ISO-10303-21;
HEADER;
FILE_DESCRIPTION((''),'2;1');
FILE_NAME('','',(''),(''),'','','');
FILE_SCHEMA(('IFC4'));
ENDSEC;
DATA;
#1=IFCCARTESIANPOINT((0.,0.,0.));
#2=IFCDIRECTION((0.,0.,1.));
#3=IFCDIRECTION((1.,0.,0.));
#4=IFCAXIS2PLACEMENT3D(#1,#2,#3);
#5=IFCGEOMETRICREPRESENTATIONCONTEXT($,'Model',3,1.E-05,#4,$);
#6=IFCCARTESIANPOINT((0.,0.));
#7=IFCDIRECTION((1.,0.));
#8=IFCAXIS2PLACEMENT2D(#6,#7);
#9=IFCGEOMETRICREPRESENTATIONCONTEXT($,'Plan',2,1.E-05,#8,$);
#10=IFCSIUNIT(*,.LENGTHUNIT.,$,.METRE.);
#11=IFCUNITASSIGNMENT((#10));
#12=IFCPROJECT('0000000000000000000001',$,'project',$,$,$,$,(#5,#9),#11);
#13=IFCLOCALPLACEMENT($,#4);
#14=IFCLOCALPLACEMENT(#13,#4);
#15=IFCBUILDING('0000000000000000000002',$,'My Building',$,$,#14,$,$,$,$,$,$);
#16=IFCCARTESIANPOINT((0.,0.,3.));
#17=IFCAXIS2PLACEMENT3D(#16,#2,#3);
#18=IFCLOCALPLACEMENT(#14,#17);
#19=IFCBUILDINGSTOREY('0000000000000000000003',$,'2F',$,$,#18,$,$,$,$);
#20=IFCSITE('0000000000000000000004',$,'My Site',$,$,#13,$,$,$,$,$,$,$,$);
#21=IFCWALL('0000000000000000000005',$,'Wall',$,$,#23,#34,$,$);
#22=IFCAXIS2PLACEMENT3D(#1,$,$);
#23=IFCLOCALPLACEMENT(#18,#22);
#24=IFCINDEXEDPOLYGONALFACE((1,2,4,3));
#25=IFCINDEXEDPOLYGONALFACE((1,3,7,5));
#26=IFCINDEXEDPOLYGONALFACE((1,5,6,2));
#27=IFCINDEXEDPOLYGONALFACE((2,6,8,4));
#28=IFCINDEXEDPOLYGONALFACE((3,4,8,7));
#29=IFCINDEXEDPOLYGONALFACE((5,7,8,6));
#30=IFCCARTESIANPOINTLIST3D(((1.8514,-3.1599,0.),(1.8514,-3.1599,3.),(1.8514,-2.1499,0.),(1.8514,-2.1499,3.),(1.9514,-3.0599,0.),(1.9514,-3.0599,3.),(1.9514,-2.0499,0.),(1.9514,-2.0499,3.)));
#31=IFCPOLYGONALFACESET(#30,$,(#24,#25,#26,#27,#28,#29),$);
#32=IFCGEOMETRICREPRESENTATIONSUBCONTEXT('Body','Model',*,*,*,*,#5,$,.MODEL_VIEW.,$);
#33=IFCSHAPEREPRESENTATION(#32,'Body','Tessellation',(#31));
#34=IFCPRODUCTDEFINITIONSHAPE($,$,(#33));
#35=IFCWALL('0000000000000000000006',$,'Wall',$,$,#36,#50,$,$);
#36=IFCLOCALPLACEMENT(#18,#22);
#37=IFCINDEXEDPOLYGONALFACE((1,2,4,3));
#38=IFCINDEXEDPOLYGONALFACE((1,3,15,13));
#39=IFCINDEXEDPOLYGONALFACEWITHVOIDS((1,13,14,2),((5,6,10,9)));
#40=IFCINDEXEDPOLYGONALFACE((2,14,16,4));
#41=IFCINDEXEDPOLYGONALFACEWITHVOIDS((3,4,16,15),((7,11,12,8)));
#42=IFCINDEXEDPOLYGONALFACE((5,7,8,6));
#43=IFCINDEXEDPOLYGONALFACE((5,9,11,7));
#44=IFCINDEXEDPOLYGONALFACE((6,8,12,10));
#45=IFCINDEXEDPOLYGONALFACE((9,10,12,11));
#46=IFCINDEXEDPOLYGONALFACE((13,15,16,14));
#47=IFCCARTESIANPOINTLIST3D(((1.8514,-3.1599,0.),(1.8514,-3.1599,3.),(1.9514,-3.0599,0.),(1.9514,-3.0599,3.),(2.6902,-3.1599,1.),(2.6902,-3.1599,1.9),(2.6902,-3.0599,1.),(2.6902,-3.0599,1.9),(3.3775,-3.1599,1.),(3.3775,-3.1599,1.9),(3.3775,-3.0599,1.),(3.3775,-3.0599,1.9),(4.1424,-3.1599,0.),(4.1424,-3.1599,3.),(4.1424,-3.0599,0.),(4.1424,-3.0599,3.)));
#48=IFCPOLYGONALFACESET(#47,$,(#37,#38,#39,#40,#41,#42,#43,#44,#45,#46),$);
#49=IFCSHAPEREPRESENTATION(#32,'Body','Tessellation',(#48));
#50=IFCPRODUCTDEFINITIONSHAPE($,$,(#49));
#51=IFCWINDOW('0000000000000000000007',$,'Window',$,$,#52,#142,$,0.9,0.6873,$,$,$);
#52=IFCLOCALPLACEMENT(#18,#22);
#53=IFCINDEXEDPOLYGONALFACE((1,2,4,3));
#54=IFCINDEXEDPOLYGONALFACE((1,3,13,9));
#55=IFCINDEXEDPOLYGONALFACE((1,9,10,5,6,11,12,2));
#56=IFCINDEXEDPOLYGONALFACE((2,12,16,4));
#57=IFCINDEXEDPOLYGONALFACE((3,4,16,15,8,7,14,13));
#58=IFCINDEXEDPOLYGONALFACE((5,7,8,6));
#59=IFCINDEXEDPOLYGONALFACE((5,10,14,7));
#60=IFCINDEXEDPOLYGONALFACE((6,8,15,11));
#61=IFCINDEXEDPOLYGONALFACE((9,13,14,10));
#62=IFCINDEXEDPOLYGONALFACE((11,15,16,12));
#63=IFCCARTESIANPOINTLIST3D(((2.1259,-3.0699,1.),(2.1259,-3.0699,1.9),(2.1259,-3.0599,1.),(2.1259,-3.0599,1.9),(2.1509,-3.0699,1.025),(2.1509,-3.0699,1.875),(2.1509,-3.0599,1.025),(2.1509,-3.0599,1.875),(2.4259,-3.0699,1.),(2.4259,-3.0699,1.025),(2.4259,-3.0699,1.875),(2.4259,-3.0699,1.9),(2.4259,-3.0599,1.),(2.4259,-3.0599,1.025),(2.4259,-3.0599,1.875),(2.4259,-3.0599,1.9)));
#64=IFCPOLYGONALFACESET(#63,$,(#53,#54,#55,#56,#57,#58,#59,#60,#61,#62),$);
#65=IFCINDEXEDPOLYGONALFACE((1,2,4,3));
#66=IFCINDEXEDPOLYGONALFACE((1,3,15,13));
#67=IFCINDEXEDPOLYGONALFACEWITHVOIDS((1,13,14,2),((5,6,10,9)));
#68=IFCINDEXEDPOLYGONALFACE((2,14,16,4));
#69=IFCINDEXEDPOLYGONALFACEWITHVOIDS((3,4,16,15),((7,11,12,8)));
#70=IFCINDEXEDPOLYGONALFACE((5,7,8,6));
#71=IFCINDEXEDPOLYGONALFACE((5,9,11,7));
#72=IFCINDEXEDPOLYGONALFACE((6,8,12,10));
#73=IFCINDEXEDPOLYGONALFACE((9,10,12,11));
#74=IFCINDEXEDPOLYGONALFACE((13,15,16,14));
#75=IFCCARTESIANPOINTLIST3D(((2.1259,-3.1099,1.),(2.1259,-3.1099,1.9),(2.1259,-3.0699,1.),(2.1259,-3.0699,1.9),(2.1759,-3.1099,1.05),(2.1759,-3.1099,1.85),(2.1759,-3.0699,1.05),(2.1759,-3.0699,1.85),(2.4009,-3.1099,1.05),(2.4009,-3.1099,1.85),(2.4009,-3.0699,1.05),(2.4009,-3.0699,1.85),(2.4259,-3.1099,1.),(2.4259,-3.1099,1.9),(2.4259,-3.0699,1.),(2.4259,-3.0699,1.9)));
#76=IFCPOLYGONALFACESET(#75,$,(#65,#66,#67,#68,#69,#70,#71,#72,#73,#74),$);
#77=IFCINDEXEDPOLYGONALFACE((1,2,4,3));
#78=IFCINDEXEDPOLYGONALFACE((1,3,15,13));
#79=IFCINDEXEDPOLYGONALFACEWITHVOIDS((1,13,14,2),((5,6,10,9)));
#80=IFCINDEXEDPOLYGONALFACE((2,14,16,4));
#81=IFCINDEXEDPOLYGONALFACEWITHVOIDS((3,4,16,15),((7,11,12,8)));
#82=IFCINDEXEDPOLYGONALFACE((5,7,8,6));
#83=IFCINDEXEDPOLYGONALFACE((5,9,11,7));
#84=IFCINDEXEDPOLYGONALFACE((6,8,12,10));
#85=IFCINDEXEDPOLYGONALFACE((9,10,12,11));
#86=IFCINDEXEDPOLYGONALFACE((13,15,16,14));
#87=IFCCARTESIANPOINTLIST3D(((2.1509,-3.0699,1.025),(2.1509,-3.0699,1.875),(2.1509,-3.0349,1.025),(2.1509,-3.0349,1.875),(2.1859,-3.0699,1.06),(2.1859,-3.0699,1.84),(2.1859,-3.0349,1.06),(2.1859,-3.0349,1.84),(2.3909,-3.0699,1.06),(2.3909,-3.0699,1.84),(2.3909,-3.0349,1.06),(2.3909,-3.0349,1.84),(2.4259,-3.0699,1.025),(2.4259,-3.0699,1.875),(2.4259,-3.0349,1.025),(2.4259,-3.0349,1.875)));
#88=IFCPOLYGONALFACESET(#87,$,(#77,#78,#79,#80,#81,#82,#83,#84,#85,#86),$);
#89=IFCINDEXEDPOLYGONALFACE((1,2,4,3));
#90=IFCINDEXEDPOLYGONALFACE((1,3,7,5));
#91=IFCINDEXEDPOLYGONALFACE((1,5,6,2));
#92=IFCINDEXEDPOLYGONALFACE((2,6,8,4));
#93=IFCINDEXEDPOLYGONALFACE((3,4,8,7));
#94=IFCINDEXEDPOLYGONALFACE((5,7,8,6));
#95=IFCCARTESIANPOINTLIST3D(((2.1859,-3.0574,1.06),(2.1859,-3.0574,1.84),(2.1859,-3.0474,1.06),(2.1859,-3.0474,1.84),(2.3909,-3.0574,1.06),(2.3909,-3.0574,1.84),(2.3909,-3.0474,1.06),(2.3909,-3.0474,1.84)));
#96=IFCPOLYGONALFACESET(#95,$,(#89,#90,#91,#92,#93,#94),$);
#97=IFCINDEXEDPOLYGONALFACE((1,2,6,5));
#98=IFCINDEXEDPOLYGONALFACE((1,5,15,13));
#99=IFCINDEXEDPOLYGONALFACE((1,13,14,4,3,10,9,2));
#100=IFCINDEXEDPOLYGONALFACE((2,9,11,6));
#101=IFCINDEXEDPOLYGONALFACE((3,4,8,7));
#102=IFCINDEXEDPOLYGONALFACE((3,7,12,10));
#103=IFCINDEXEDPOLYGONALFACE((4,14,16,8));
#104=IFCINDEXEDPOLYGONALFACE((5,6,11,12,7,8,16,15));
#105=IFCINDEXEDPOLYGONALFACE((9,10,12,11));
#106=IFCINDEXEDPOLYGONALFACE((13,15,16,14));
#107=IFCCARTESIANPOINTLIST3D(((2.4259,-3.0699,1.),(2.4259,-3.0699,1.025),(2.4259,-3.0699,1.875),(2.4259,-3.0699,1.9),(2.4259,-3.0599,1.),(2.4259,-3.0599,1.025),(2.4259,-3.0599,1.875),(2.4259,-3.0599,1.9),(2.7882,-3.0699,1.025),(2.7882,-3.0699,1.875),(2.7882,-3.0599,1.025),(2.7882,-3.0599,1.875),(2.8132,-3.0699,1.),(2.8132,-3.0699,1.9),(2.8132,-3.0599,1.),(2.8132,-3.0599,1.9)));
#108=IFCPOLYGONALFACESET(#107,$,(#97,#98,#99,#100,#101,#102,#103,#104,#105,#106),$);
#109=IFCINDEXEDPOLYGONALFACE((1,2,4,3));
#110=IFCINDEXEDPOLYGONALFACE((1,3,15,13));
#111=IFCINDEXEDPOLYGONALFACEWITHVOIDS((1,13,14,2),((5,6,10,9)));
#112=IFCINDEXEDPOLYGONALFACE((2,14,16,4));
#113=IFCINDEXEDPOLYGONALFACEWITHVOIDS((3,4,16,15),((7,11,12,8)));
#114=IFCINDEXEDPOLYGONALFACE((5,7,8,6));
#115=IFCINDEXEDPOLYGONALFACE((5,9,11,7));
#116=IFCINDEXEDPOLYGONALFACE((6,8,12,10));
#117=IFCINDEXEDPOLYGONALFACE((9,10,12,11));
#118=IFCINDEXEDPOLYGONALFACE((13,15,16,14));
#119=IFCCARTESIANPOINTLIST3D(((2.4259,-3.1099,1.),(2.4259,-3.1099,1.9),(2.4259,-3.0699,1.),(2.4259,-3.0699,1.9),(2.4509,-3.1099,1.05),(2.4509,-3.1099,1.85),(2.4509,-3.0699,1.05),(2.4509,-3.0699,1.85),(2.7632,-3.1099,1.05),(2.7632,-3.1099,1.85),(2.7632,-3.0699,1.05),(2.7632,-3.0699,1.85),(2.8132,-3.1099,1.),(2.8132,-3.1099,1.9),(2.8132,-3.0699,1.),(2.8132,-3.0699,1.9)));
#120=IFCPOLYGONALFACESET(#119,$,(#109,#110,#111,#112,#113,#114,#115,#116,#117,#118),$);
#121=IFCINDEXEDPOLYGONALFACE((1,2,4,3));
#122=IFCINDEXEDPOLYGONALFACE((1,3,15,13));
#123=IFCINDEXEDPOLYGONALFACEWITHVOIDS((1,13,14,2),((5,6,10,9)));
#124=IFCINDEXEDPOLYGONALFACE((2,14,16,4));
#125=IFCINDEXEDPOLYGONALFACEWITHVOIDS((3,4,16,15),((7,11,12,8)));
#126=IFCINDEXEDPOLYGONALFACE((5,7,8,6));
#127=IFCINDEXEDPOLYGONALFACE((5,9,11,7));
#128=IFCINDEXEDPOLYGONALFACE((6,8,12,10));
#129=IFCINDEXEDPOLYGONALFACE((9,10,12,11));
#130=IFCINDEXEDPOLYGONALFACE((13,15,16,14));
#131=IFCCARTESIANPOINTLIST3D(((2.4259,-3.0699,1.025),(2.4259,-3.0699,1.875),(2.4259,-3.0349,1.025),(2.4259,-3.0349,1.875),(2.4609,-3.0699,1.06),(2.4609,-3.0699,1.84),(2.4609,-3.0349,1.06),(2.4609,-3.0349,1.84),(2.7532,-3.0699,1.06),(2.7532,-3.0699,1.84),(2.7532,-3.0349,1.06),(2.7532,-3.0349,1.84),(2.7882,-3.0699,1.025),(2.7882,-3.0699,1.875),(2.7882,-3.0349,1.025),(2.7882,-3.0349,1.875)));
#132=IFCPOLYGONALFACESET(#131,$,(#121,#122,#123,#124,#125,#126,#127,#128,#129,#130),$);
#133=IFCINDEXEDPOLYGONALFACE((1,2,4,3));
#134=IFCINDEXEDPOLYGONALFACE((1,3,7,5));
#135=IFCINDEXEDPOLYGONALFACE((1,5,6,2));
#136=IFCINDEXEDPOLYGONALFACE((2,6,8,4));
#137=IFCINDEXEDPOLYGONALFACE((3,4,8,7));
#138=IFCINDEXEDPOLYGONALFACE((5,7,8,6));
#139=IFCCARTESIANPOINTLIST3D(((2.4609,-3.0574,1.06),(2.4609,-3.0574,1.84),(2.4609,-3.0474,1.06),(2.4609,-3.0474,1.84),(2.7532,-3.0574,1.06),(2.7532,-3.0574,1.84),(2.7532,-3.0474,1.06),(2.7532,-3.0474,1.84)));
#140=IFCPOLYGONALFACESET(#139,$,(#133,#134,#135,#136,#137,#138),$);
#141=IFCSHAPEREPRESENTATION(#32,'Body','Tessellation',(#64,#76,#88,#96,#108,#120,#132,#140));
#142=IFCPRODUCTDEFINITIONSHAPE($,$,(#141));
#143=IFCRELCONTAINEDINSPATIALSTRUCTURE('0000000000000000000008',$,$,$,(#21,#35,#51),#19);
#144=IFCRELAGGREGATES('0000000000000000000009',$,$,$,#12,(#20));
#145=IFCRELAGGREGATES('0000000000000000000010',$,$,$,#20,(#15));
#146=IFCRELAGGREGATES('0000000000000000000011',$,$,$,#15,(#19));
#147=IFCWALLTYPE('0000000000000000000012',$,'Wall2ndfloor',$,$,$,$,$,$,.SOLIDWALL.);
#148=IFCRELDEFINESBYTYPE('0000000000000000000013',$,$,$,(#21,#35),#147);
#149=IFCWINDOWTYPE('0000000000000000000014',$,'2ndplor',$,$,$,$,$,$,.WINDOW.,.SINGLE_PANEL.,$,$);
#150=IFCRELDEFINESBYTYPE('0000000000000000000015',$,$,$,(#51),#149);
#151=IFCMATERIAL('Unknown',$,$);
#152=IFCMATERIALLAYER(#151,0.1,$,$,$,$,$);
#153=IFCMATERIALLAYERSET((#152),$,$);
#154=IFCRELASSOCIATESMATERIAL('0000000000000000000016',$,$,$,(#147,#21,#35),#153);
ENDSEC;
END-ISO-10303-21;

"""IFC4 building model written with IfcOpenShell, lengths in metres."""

from ifc_helpers import new_model, entity, si_unit, frame, origin_with_axes, origin_2d_with_axis, place, context, subcontext, project, spatial, line, indexed_curve, outline, extrude, shape, source, transform, mapped, material, layer, layer_set, layer_usage, type_object, type_shapes, element, fill, save


model = new_model("IFC4")

# Units and contexts
model_context = context("Model", 3, precision=1e-05, world=origin_with_axes())
plan_context = context("Plan", 2, precision=1e-05, world=origin_2d_with_axis())
body_context_1 = subcontext(model_context, "Body", "Model", "MODEL_VIEW")
body_context_2 = subcontext(plan_context, "Body", "Plan", "PLAN_VIEW")
ifc_project = project(units=[si_unit("LENGTHUNIT", "METRE")], contexts=[model_context, plan_context])

# Site, building, storey
site_placement = place(None, origin_with_axes())
site = spatial("IfcSite", under=ifc_project, at=site_placement, Name="My Site")
building_placement = place(site_placement, origin_with_axes())
building = spatial("IfcBuilding", under=site, at=building_placement, Name="My Building")
storey_placement = place(building_placement, frame((0.0, 0.0, 3.0), z_axis=(0.0, 0.0, 1.0), x_axis=(1.0, 0.0, 0.0)))
storey = spatial("IfcBuildingStorey", under=building, at=storey_placement, Name="2F")

# Shared definitions
ifc_material = material(Name="Unknown")

# Shared definitions
ifc_layer_1 = layer(ifc_material, 0.1)
ifc_layer_set_1 = layer_set([ifc_layer_1])
wall_type = type_object("IfcWallType", Name="Wall2ndfloor", PredefinedType="SOLIDWALL", material=ifc_layer_set_1)

# Wall
ifc_layer_usage_1 = layer_usage(ifc_layer_set_1, "AXIS2", "POSITIVE", 0.0)
wall_1_placement = place(storey_placement, frame((1.8514, -2.0499, 0.0), z_axis=(0.0, 0.0, 1.0), x_axis=(0.0, -1.0, 0.0)))
element("IfcWall", 1, at=wall_1_placement, inside=storey, type_object=wall_type, material=ifc_layer_usage_1, Name="Wall", context=body_context_1, shape_type="SweptSolid", body=[
    extrude(outline(indexed_curve([(0.1, 0.0), (0.0, 0.1), (1.01, 0.1), (1.11, 0.0)], segments=[line(1, 2, 3, 4, 1)])), origin_with_axes(), (0.0, 0.0, 1.0), 3.0),
])

# Wall, opening, window
ifc_layer_usage_2 = layer_usage(ifc_layer_set_1, "AXIS2", "POSITIVE", 0.0)
wall_2_placement = place(storey_placement, frame((1.8514, -3.1599, 0.0), z_axis=(0.0, 0.0, 1.0), x_axis=(1.0, 0.0, 0.0)))
wall_2 = element("IfcWall", 2, at=wall_2_placement, inside=storey, type_object=wall_type, material=ifc_layer_usage_2, Name="Wall", context=body_context_1, shape_type="SweptSolid", body=[
    extrude(outline(indexed_curve([(0.0, 0.0), (0.1, 0.1), (2.291, 0.1), (2.291, 0.0)], segments=[line(1, 2, 3, 4, 1)])), origin_with_axes(), (0.0, 0.0, 1.0), 3.0),
])
shared_shape_1 = source(origin_with_axes(), body_context_1, "Body", "SweptSolid", [
    extrude(outline(indexed_curve([(0.0, 0.0), (0.6873, 0.0), (0.6873, 0.9), (0.0, 0.9)], segments=[line(1, 2, 3, 4, 1)])), frame((0.0, -0.6, 0.0), z_axis=(0.0, -1.0, 0.0), x_axis=(1.0, 0.0, 0.0)), (0.0, 0.0, -1.0), 1.2),
])
opening_1_placement = place(wall_2_placement, frame((1.5262, 0.1, 1.0), z_axis=(0.0, 0.0, 1.0), x_axis=(-1.0, 0.0, 0.0)))
opening_1 = element("IfcOpeningElement", 3, at=opening_1_placement, cuts=wall_2, PredefinedType="OPENING", context=body_context_1, shape_type="MappedRepresentation", body=[
    mapped(shared_shape_1, transform((0.0, 0.0, 0.0), x_axis=(1.0, 0.0, 0.0), y_axis=(0.0, 1.0, 0.0), z_axis=(0.0, 0.0, 1.0), scale=1.0)),
])
window_type_1 = type_object("IfcWindowType", Name="2ndplor", PartitioningType="SINGLE_PANEL", PredefinedType="WINDOW")
shared_shape_2 = source(origin_with_axes(), body_context_1, "Body", "SweptSolid", [
    extrude(outline(indexed_curve([(0.3, 0.0), (0.0, 0.0), (0.0, 0.9), (0.3, 0.9), (0.3, 0.875), (0.025, 0.875), (0.025, 0.025), (0.3, 0.025)], segments=[line(1, 2, 3, 4, 5, 6, 7, 8, 1)])), frame((0.0, 0.09, 0.0), z_axis=(0.0, -1.0, 0.0), x_axis=(1.0, 0.0, 0.0)), (0.0, 0.0, -1.0), 0.01),
    extrude(outline(indexed_curve([(0.0, 0.0), (0.3, 0.0), (0.3, 0.9), (0.0, 0.9)], segments=[line(1, 2, 3, 4, 1)]), holes=[indexed_curve([(0.05, 0.05), (0.275, 0.05), (0.275, 0.85), (0.05, 0.85)], segments=[line(1, 2, 3, 4, 1)])]), frame((0.0, 0.05, 0.0), z_axis=(0.0, -1.0, 0.0), x_axis=(1.0, 0.0, 0.0)), (0.0, 0.0, -1.0), 0.04),
    extrude(outline(indexed_curve([(0.0, 0.0), (0.275, 0.0), (0.275, 0.85), (0.0, 0.85)], segments=[line(1, 2, 3, 4, 1)]), holes=[indexed_curve([(0.035, 0.035), (0.24, 0.035), (0.24, 0.815), (0.035, 0.815)], segments=[line(1, 2, 3, 4, 1)])]), frame((0.025, 0.09, 0.025), z_axis=(0.0, -1.0, 0.0), x_axis=(1.0, 0.0, 0.0)), (0.0, 0.0, -1.0), 0.035),
    extrude(outline(indexed_curve([(0.035, 0.035), (0.24, 0.035), (0.24, 0.815), (0.035, 0.815)], segments=[line(1, 2, 3, 4, 1)])), frame((0.025, 0.1025, 0.025), z_axis=(0.0, -1.0, 0.0), x_axis=(1.0, 0.0, 0.0)), (0.0, 0.0, -1.0), 0.01),
    extrude(outline(indexed_curve([(0.0, 0.9), (0.3873, 0.9), (0.3873, 0.0), (0.0, 0.0), (0.0, 0.025), (0.3623, 0.025), (0.3623, 0.875), (0.0, 0.875)], segments=[line(1, 2, 3, 4, 5, 6, 7, 8, 1)])), frame((0.3, 0.09, 0.0), z_axis=(0.0, -1.0, 0.0), x_axis=(1.0, 0.0, 0.0)), (0.0, 0.0, -1.0), 0.01),
    extrude(outline(indexed_curve([(0.0, 0.0), (0.3873, 0.0), (0.3873, 0.9), (0.0, 0.9)], segments=[line(1, 2, 3, 4, 1)]), holes=[indexed_curve([(0.025, 0.05), (0.3373, 0.05), (0.3373, 0.85), (0.025, 0.85)], segments=[line(1, 2, 3, 4, 1)])]), frame((0.3, 0.05, 0.0), z_axis=(0.0, -1.0, 0.0), x_axis=(1.0, 0.0, 0.0)), (0.0, 0.0, -1.0), 0.04),
    extrude(outline(indexed_curve([(0.0, 0.0), (0.3623, 0.0), (0.3623, 0.85), (0.0, 0.85)], segments=[line(1, 2, 3, 4, 1)]), holes=[indexed_curve([(0.035, 0.035), (0.3273, 0.035), (0.3273, 0.815), (0.035, 0.815)], segments=[line(1, 2, 3, 4, 1)])]), frame((0.3, 0.09, 0.025), z_axis=(0.0, -1.0, 0.0), x_axis=(1.0, 0.0, 0.0)), (0.0, 0.0, -1.0), 0.035),
    extrude(outline(indexed_curve([(0.035, 0.035), (0.3273, 0.035), (0.3273, 0.815), (0.035, 0.815)], segments=[line(1, 2, 3, 4, 1)])), frame((0.3, 0.1025, 0.025), z_axis=(0.0, -1.0, 0.0), x_axis=(1.0, 0.0, 0.0)), (0.0, 0.0, -1.0), 0.01),
])
shared_shape_3 = source(origin_with_axes(), body_context_2, "Body", "Curve2D", [
    entity("IfcIndexedPolyCurve", entity("IfcCartesianPointList2D", [[0.05, 0.05], [0.275, 0.05]])),
    entity("IfcIndexedPolyCurve", entity("IfcCartesianPointList2D", [[0.0, 0.1], [0.025, 0.1], [0.025, 0.09], [0.05, 0.09], [0.05, 0.05], [0.0, 0.05]]), [entity("IfcLineIndex", [1, 2, 3, 4, 5, 6, 1])]),
    entity("IfcIndexedPolyCurve", entity("IfcCartesianPointList2D", [[0.3, 0.1], [0.3, 0.1], [0.3, 0.09], [0.275, 0.09], [0.275, 0.05], [0.3, 0.05]])),
    entity("IfcIndexedPolyCurve", entity("IfcCartesianPointList2D", [[0.025, 0.09], [0.06, 0.09], [0.06, 0.125], [0.025, 0.125]]), [entity("IfcLineIndex", [1, 2, 3, 4, 1])]),
    entity("IfcIndexedPolyCurve", entity("IfcCartesianPointList2D", [[0.3, 0.09], [0.265, 0.09], [0.265, 0.125], [0.3, 0.125]]), [entity("IfcLineIndex", [1, 2, 3, 4, 1])]),
    entity("IfcIndexedPolyCurve", entity("IfcCartesianPointList2D", [[0.06, 0.09], [0.265, 0.09]])),
    entity("IfcIndexedPolyCurve", entity("IfcCartesianPointList2D", [[0.06, 0.125], [0.265, 0.125]])),
    entity("IfcIndexedPolyCurve", entity("IfcCartesianPointList2D", [[0.06, 0.1075], [0.265, 0.1075]])),
    entity("IfcIndexedPolyCurve", entity("IfcCartesianPointList2D", [[0.325, 0.05], [0.6373, 0.05]])),
    entity("IfcIndexedPolyCurve", entity("IfcCartesianPointList2D", [[0.3, 0.1], [0.3, 0.1], [0.3, 0.09], [0.325, 0.09], [0.325, 0.05], [0.3, 0.05]])),
    entity("IfcIndexedPolyCurve", entity("IfcCartesianPointList2D", [[0.6873, 0.1], [0.6623, 0.1], [0.6623, 0.09], [0.6373, 0.09], [0.6373, 0.05], [0.6873, 0.05]]), [entity("IfcLineIndex", [1, 2, 3, 4, 5, 6, 1])]),
    entity("IfcIndexedPolyCurve", entity("IfcCartesianPointList2D", [[0.3, 0.09], [0.335, 0.09], [0.335, 0.125], [0.3, 0.125]]), [entity("IfcLineIndex", [1, 2, 3, 4, 1])]),
    entity("IfcIndexedPolyCurve", entity("IfcCartesianPointList2D", [[0.6623, 0.09], [0.6273, 0.09], [0.6273, 0.125], [0.6623, 0.125]]), [entity("IfcLineIndex", [1, 2, 3, 4, 1])]),
    entity("IfcIndexedPolyCurve", entity("IfcCartesianPointList2D", [[0.335, 0.09], [0.6273, 0.09]])),
    entity("IfcIndexedPolyCurve", entity("IfcCartesianPointList2D", [[0.335, 0.125], [0.6273, 0.125]])),
    entity("IfcIndexedPolyCurve", entity("IfcCartesianPointList2D", [[0.335, 0.1075], [0.6273, 0.1075]])),
])
type_shapes(window_type_1, [shared_shape_2, shared_shape_3])
window_1_placement = place(opening_1_placement, frame((1.2517, 0.1, 0.0), z_axis=(0.0, 0.0, 1.0), x_axis=(-1.0, 0.0, 0.0)))
window_1 = element("IfcWindow", 4, at=window_1_placement, inside=storey, type_object=window_type_1, Name="Window", OverallHeight=0.9, OverallWidth=0.6873, shapes=[
    shape(body_context_1, "Body", "MappedRepresentation", [mapped(shared_shape_2, transform((0.0, 0.0, 0.0), x_axis=(1.0, 0.0, 0.0), y_axis=(0.0, 1.0, 0.0), z_axis=(0.0, 0.0, 1.0), scale=1.0))]),
    shape(body_context_2, "Body", "MappedRepresentation", [mapped(shared_shape_3, transform((0.0, 0.0, 0.0), x_axis=(1.0, 0.0, 0.0), y_axis=(0.0, 1.0, 0.0), z_axis=(0.0, 0.0, 1.0), scale=1.0))]),
])
fill(opening_1, window_1)

save(model, "model.ifc")
